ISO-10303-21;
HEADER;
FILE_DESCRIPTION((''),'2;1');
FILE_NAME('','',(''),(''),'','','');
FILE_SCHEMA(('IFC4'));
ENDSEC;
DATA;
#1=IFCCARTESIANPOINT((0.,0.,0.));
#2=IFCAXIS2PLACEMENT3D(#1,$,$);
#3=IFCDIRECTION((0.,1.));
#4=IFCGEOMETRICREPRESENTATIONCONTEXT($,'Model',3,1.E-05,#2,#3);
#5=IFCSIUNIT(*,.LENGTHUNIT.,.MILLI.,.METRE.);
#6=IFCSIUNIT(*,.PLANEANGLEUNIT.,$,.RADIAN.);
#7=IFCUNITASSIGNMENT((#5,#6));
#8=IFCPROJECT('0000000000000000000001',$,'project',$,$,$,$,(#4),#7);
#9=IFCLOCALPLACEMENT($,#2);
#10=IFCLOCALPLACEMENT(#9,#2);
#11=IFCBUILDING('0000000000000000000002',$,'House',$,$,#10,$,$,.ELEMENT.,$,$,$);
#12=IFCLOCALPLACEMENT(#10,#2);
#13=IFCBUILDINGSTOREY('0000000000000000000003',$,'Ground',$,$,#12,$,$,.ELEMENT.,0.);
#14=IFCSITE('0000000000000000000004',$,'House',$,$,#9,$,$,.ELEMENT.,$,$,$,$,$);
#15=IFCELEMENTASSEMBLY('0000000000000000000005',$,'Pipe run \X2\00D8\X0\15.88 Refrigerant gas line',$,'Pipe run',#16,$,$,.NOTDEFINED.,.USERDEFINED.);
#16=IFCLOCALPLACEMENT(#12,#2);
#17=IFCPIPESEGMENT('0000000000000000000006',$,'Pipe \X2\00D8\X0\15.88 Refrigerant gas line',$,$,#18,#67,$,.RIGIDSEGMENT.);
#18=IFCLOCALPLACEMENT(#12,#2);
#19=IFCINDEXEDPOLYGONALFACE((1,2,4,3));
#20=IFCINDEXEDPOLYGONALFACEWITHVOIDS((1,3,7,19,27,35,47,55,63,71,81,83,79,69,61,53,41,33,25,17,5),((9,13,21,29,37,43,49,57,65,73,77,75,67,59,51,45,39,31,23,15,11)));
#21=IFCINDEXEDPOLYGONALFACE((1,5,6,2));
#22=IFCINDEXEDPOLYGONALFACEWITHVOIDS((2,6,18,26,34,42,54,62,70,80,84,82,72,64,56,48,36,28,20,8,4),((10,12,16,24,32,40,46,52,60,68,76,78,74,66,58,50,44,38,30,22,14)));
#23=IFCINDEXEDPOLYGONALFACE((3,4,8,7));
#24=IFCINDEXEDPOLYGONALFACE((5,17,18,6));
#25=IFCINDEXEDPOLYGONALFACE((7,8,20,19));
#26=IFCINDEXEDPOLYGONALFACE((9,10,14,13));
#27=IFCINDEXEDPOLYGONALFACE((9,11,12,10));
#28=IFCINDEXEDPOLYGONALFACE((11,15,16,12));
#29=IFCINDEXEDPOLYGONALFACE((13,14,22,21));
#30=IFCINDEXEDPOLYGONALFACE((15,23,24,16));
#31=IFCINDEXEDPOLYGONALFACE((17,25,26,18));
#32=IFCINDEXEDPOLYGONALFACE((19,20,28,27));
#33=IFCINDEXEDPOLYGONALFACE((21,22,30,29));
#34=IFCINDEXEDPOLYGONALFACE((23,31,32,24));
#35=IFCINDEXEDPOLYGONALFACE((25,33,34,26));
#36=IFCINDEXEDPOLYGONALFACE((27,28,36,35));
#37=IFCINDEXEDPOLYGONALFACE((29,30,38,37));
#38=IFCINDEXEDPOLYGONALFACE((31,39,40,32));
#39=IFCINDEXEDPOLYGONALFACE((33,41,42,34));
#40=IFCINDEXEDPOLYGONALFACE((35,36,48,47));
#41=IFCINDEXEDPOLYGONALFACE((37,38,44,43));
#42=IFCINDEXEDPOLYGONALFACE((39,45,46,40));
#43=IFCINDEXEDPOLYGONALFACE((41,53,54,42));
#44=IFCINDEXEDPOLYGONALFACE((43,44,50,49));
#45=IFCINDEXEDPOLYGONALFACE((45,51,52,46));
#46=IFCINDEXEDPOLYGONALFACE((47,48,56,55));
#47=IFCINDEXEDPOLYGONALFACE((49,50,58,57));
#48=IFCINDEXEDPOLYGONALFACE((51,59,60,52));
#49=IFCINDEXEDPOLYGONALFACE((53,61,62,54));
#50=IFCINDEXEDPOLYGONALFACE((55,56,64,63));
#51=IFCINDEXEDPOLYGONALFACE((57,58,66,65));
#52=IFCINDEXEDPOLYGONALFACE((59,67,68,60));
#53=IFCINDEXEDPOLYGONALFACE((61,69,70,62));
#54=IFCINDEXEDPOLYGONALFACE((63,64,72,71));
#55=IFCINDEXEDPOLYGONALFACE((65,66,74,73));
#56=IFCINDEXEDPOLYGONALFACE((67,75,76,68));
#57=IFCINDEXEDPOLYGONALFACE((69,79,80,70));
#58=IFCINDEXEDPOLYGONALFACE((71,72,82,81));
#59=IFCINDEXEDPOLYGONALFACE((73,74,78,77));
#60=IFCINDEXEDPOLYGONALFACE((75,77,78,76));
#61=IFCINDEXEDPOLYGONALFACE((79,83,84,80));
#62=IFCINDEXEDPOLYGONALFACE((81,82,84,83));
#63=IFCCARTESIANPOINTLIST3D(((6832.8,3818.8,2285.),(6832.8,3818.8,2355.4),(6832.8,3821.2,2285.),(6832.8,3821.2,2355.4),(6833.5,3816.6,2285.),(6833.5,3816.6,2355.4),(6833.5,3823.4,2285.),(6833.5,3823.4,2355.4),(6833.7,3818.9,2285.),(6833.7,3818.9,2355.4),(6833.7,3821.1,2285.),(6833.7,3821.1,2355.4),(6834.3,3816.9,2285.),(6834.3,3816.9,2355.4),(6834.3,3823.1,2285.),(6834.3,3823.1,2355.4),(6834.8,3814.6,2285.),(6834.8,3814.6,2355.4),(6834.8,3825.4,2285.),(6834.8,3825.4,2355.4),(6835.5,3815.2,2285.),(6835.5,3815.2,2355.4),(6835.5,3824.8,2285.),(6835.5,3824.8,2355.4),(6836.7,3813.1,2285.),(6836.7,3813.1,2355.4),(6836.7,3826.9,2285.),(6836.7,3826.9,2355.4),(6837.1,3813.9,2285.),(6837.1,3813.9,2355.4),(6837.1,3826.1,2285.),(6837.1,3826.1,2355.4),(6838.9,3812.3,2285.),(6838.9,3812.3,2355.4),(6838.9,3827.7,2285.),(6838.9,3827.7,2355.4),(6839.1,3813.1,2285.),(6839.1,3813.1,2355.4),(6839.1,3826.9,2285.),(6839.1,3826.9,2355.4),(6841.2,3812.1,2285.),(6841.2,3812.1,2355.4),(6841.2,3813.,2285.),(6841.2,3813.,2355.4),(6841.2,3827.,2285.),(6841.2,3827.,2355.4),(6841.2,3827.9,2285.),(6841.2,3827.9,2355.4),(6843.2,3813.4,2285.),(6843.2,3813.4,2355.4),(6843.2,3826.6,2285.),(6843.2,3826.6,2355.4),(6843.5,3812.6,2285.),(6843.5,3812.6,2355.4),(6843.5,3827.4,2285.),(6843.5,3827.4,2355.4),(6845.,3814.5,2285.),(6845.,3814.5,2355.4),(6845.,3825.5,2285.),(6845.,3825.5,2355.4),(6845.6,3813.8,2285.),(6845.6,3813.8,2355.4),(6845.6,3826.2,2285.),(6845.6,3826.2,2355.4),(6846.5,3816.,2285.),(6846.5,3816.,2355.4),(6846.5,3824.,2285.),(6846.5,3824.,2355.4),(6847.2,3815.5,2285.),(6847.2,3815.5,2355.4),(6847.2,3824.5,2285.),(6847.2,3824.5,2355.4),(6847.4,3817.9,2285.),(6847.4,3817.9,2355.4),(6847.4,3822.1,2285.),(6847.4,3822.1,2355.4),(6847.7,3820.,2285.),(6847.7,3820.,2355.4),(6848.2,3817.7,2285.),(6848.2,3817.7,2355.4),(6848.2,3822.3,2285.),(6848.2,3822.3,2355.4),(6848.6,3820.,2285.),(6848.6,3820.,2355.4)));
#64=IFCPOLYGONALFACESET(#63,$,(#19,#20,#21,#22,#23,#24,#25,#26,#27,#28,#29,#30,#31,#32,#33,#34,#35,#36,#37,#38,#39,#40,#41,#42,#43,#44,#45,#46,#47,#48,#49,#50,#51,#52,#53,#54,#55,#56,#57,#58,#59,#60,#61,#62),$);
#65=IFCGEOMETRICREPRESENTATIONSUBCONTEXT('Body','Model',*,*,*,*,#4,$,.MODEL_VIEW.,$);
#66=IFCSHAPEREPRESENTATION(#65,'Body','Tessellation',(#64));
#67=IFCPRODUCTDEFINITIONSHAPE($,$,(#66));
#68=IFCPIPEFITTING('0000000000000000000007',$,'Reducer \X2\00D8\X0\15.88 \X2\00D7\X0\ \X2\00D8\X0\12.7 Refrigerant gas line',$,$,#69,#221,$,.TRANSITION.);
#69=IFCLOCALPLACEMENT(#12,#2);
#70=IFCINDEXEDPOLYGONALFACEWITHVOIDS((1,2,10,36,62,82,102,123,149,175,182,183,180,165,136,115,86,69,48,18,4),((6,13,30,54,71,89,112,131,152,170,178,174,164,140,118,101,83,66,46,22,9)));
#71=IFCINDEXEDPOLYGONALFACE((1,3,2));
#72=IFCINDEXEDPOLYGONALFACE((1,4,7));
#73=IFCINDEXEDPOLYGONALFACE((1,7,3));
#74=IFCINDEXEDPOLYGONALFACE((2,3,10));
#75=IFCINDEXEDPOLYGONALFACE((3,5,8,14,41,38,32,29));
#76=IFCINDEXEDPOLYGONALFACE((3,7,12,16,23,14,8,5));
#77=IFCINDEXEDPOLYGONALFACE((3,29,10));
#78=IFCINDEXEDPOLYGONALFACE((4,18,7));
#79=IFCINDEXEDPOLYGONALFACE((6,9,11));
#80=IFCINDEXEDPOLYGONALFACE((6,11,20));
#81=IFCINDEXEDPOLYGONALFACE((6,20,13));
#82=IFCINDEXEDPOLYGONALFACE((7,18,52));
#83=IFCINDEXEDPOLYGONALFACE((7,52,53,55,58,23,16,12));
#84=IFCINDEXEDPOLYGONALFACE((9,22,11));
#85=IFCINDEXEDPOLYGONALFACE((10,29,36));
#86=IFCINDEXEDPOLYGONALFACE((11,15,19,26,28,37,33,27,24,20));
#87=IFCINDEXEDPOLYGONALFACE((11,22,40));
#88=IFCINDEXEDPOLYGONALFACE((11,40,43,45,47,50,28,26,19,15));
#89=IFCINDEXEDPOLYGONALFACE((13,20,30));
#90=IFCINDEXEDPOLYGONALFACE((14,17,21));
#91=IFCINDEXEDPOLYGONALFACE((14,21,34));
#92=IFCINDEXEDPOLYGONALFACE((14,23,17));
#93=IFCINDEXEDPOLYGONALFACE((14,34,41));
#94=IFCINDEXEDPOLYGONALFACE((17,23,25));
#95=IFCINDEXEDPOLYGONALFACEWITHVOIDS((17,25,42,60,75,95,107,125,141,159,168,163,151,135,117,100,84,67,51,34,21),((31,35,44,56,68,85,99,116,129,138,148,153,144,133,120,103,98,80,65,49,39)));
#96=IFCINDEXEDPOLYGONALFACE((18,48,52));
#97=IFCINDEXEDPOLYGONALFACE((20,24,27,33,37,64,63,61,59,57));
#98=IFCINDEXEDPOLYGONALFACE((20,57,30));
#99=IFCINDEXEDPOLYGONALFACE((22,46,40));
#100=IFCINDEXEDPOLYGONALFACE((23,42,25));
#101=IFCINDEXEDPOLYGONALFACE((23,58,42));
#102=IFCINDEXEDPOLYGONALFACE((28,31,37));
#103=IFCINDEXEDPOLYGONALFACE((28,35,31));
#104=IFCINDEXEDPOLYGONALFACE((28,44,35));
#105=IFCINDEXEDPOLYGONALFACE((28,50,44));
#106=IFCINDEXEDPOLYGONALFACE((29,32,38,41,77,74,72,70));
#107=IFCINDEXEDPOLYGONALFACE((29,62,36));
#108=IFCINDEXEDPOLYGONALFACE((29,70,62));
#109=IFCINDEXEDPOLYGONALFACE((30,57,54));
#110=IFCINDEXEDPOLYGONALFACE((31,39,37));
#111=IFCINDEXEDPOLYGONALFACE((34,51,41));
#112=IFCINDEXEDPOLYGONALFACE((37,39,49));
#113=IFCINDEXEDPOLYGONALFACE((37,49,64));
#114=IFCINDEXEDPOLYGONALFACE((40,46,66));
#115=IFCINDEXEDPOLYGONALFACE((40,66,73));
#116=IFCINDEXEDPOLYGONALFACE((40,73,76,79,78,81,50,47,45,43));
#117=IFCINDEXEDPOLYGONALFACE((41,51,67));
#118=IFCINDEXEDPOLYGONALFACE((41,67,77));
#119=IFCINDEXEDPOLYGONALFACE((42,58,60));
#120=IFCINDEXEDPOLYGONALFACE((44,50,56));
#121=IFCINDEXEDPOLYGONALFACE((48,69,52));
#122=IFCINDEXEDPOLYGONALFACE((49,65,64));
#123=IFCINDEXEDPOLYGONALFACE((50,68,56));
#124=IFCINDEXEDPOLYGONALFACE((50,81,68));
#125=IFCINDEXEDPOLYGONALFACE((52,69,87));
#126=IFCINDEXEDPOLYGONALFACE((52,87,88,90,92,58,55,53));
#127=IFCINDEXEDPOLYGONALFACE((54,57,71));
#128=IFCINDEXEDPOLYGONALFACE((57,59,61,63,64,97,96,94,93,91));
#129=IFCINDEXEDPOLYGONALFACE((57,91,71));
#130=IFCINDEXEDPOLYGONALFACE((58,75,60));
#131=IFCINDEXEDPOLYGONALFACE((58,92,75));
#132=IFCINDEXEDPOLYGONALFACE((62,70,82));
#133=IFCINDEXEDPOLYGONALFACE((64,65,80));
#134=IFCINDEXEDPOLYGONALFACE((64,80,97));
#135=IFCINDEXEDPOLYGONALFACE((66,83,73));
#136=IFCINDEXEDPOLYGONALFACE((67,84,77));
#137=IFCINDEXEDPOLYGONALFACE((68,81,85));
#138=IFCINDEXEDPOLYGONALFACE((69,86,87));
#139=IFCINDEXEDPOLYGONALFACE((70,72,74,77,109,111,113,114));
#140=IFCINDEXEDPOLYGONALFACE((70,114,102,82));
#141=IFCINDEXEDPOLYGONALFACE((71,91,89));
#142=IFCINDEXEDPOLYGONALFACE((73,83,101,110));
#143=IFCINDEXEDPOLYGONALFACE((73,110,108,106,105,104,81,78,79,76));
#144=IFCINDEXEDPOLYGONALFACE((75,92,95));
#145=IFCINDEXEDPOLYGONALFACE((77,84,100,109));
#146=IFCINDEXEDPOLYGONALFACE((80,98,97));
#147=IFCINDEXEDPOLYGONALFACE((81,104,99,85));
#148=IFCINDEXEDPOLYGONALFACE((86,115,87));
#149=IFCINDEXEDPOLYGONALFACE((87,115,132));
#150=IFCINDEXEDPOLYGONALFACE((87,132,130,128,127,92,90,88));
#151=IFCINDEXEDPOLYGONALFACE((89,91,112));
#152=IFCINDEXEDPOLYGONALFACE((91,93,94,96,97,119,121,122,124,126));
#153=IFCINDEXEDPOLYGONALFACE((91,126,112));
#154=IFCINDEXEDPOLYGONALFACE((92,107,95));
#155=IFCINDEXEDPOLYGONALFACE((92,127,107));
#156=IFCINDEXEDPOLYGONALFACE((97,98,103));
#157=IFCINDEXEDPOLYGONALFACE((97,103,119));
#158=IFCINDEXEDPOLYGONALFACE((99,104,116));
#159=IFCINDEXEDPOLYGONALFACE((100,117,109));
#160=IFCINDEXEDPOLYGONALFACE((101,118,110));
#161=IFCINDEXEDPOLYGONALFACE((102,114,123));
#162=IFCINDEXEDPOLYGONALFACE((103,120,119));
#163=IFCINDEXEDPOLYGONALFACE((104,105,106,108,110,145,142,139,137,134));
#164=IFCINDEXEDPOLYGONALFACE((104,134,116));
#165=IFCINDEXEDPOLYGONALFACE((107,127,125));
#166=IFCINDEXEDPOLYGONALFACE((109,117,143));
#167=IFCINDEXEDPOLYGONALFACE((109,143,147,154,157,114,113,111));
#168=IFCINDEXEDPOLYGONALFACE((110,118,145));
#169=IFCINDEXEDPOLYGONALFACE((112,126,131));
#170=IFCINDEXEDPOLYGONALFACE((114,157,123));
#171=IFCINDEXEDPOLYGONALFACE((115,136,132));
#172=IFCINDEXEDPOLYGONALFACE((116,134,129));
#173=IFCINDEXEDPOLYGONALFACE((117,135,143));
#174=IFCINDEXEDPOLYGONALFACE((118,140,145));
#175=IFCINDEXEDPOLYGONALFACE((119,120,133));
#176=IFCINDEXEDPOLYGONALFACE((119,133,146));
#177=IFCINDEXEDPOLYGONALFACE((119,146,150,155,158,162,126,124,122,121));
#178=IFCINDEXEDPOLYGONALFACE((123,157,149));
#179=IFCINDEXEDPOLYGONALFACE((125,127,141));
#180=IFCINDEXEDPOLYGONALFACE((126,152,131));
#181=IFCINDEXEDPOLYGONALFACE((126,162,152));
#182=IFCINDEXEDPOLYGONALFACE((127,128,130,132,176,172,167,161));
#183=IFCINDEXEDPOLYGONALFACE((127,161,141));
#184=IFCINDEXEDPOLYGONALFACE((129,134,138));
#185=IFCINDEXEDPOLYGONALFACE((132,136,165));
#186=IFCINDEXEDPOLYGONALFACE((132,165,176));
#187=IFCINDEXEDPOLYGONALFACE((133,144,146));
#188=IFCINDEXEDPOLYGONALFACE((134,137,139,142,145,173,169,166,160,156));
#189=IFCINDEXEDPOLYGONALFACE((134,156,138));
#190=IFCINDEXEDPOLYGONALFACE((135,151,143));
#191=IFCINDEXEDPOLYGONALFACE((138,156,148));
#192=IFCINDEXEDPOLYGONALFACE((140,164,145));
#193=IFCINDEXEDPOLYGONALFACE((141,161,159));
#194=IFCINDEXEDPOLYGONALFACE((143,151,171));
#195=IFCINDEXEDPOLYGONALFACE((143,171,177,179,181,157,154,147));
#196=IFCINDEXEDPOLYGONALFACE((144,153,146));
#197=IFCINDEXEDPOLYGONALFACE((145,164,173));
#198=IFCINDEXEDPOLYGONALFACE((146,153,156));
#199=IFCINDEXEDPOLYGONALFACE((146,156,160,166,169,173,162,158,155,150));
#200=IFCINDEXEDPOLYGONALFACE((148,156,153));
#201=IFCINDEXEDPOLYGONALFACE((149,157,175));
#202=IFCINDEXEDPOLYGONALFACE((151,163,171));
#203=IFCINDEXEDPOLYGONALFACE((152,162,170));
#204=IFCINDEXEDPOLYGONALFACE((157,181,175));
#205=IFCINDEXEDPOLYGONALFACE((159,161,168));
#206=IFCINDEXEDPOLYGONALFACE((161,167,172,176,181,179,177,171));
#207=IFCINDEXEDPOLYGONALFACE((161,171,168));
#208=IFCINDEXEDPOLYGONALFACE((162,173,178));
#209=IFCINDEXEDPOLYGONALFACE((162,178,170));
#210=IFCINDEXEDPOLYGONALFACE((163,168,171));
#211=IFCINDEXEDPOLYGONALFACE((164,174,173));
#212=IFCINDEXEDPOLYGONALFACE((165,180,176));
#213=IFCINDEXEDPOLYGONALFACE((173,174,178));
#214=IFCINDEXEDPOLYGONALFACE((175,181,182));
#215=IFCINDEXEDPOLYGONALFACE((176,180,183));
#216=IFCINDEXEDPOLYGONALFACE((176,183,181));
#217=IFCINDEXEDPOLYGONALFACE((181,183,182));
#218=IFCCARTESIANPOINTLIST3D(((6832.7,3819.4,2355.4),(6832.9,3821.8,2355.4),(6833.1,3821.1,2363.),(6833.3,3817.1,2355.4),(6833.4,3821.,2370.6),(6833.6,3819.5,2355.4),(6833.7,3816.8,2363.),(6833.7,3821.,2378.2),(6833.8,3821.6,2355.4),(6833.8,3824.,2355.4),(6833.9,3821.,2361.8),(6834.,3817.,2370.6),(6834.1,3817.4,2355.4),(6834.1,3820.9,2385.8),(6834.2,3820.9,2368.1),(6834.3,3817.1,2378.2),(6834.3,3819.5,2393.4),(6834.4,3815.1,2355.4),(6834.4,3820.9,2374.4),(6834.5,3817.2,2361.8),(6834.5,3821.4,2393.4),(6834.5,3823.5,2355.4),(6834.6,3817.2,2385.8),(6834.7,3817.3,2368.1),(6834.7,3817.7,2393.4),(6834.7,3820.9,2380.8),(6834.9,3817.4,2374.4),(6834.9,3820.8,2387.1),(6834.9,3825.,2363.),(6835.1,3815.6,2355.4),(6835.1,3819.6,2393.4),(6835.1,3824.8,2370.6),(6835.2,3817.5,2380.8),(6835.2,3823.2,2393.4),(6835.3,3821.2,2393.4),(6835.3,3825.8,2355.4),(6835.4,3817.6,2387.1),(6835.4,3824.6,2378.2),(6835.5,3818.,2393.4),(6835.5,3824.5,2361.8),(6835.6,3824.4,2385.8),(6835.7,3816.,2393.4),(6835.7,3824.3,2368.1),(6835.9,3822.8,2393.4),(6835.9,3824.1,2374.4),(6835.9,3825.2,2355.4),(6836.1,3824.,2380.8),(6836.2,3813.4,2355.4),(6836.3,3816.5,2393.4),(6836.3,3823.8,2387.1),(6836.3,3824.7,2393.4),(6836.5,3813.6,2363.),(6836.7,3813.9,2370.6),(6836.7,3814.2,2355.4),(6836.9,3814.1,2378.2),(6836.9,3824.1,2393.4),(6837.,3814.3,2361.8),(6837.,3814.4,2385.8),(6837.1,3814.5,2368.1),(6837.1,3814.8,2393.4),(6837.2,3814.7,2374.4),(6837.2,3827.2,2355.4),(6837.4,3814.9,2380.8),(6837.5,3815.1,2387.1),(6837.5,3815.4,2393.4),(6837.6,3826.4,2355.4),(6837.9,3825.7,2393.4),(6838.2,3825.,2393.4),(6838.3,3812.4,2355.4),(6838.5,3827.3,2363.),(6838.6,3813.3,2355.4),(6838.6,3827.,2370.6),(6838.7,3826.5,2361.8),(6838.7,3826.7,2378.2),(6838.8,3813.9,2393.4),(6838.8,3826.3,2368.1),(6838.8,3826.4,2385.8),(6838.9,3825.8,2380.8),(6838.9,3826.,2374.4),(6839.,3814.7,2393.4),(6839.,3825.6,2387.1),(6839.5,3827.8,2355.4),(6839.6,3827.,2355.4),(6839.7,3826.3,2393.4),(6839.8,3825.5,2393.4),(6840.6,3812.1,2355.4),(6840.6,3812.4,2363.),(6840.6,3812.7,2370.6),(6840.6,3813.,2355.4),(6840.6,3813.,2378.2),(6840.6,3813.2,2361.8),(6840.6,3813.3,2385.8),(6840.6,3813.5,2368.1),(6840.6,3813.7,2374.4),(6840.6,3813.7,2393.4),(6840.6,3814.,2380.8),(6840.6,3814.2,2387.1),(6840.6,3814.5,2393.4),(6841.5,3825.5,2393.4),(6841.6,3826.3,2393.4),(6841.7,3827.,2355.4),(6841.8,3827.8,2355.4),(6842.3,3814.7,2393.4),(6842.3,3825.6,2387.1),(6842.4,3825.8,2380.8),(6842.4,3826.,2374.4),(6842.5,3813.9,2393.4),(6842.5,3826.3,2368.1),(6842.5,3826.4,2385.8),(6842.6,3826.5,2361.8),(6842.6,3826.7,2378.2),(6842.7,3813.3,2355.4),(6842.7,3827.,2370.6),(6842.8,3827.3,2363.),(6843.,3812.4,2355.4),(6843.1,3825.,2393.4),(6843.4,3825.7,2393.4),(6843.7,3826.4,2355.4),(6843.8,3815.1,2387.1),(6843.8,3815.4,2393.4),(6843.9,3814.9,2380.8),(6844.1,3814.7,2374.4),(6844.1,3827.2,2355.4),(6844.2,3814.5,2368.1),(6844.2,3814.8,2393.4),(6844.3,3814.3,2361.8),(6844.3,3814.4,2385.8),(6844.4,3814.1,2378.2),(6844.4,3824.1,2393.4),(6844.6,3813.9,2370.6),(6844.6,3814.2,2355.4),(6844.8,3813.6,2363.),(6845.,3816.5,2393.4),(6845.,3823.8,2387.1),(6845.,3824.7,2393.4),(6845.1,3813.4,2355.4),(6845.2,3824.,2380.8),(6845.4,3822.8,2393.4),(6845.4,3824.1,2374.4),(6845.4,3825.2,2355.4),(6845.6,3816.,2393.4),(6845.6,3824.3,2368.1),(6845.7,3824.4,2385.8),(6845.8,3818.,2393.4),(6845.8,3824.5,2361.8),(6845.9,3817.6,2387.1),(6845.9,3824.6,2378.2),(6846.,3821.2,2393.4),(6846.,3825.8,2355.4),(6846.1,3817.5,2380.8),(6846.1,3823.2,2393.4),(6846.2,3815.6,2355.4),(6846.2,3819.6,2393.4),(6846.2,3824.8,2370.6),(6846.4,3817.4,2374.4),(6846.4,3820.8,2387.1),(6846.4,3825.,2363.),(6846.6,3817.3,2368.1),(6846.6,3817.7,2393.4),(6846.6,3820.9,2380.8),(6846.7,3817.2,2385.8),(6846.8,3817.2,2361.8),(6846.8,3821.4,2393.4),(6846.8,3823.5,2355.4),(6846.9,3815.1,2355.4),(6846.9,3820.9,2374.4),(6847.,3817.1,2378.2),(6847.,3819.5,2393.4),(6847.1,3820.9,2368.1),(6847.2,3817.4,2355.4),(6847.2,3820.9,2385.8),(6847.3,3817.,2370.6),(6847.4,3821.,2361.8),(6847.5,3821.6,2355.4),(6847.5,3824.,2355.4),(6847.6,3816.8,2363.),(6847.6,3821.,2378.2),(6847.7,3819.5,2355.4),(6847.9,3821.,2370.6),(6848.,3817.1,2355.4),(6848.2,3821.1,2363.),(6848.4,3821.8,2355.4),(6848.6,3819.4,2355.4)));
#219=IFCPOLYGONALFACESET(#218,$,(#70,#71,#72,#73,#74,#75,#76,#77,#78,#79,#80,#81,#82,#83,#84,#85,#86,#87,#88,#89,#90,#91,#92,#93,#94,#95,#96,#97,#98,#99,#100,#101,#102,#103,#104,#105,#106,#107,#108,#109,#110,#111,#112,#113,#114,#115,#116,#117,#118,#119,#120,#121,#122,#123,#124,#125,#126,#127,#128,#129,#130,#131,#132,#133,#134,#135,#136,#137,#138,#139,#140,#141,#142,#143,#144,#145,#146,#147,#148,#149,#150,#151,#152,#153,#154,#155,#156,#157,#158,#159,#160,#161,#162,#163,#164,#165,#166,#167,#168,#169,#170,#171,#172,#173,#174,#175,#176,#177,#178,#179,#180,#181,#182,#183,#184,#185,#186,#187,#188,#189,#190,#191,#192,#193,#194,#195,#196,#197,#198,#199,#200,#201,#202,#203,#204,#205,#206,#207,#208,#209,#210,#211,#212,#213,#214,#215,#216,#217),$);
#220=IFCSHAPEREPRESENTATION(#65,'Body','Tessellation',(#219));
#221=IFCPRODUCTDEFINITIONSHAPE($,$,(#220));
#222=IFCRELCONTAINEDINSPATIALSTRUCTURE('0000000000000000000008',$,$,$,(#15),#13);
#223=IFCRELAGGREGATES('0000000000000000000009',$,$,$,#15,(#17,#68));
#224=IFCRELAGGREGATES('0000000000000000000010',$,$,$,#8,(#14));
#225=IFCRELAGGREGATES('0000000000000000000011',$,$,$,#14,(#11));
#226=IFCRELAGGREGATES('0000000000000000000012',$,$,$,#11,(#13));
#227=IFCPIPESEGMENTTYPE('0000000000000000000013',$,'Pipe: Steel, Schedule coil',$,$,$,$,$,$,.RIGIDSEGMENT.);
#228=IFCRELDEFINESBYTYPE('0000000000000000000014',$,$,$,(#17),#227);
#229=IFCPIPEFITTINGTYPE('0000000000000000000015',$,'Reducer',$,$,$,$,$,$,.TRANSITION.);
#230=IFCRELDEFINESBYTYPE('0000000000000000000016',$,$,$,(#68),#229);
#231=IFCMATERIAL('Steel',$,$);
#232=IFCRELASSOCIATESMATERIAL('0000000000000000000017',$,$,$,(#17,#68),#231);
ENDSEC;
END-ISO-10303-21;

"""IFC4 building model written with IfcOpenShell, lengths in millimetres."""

from ifc_helpers import new_model, entity, si_unit, direction, frame, origin, origin_with_axes, origin_2d, place, context, subcontext, project, spatial, hollow_circle, extrude, material, type_object, element, aggregate, save


model = new_model("IFC4")

# Units and contexts
model_context = context("Model", 3, precision=1e-05, world=origin(), true_north=direction((0.0, 1.0)))
body_context = subcontext(model_context, "Body", "Model", "MODEL_VIEW")
ifc_project = project(units=[si_unit("LENGTHUNIT", "METRE", prefix="MILLI"), si_unit("PLANEANGLEUNIT", "RADIAN")], contexts=[model_context])

# Site, building, storey
site_placement = place(None, origin())
site = spatial("IfcSite", under=ifc_project, at=site_placement, Name="House", CompositionType="ELEMENT")
building_placement = place(site_placement, origin())
building = spatial("IfcBuilding", under=site, at=building_placement, Name="House", CompositionType="ELEMENT")
storey_placement = place(building_placement, origin())
storey = spatial("IfcBuildingStorey", under=building, at=storey_placement, Name="Ground", CompositionType="ELEMENT", Elevation=0.0)

# Element assembly, pipe segment
ifc_material = material(Name="Steel")
pipe_segment_type = type_object("IfcPipeSegmentType", Name="Pipe: Steel, Schedule coil", PredefinedType="RIGIDSEGMENT")
assembly_1_placement = place(storey_placement, origin_with_axes())
assembly_1 = element("IfcElementAssembly", 1, at=assembly_1_placement, inside=storey, Name="Pipe run Ø15.88 Refrigerant gas line", ObjectType="Pipe run", AssemblyPlace="NOTDEFINED", PredefinedType="USERDEFINED")
pipe_segment_1_placement = place(storey_placement, origin_with_axes())
pipe_segment_1 = element("IfcPipeSegment", 2, at=pipe_segment_1_placement, type_object=pipe_segment_type, material=ifc_material, Name="Pipe Ø15.88 Refrigerant gas line", PredefinedType="RIGIDSEGMENT", context=body_context, shape_type="SweptSolid", body=[
    extrude(hollow_circle(Radius=7.9, WallThickness=0.9, at=origin_2d()), frame((6840.6, 3820.0, 2285.0), z_axis=(0.0, 0.0, 1.0), x_axis=(1.0, 0.0, 0.0)), (0.0, 0.0, 1.0), 70.4),
])

# Pipe fitting
pipe_fitting_type_1 = type_object("IfcPipeFittingType", Name="Reducer", PredefinedType="TRANSITION")
pipe_fitting_1_placement = place(storey_placement, origin_with_axes())
cartesian_point = entity("IfcCartesianPoint", [0.0, 7.0])
pipe_fitting_1 = element("IfcPipeFitting", 3, at=pipe_fitting_1_placement, type_object=pipe_fitting_type_1, material=ifc_material, Name="Reducer Ø15.88 × Ø12.7 Refrigerant gas line", PredefinedType="TRANSITION", context=body_context, shape_type="SweptSolid", body=[
    entity("IfcRevolvedAreaSolid", entity("IfcArbitraryClosedProfileDef", "AREA", None, entity("IfcPolyline", [cartesian_point, entity("IfcCartesianPoint", [0.0, 7.9]), entity("IfcCartesianPoint", [38.0, 6.3]), entity("IfcCartesianPoint", [38.0, 5.5]), cartesian_point])), entity("IfcAxis2Placement3D", entity("IfcCartesianPoint", [6840.6, 3820.0, 2355.4]), entity("IfcDirection", [1.0, 0.0, 0.0]), entity("IfcDirection", [0.0, 0.0, 1.0])), entity("IfcAxis1Placement", entity("IfcCartesianPoint", [0.0, 0.0, 0.0]), entity("IfcDirection", [1.0, 0.0, 0.0])), 6.283185),
])
aggregate(assembly_1, [pipe_segment_1, pipe_fitting_1])

save(model, "model.ifc")
